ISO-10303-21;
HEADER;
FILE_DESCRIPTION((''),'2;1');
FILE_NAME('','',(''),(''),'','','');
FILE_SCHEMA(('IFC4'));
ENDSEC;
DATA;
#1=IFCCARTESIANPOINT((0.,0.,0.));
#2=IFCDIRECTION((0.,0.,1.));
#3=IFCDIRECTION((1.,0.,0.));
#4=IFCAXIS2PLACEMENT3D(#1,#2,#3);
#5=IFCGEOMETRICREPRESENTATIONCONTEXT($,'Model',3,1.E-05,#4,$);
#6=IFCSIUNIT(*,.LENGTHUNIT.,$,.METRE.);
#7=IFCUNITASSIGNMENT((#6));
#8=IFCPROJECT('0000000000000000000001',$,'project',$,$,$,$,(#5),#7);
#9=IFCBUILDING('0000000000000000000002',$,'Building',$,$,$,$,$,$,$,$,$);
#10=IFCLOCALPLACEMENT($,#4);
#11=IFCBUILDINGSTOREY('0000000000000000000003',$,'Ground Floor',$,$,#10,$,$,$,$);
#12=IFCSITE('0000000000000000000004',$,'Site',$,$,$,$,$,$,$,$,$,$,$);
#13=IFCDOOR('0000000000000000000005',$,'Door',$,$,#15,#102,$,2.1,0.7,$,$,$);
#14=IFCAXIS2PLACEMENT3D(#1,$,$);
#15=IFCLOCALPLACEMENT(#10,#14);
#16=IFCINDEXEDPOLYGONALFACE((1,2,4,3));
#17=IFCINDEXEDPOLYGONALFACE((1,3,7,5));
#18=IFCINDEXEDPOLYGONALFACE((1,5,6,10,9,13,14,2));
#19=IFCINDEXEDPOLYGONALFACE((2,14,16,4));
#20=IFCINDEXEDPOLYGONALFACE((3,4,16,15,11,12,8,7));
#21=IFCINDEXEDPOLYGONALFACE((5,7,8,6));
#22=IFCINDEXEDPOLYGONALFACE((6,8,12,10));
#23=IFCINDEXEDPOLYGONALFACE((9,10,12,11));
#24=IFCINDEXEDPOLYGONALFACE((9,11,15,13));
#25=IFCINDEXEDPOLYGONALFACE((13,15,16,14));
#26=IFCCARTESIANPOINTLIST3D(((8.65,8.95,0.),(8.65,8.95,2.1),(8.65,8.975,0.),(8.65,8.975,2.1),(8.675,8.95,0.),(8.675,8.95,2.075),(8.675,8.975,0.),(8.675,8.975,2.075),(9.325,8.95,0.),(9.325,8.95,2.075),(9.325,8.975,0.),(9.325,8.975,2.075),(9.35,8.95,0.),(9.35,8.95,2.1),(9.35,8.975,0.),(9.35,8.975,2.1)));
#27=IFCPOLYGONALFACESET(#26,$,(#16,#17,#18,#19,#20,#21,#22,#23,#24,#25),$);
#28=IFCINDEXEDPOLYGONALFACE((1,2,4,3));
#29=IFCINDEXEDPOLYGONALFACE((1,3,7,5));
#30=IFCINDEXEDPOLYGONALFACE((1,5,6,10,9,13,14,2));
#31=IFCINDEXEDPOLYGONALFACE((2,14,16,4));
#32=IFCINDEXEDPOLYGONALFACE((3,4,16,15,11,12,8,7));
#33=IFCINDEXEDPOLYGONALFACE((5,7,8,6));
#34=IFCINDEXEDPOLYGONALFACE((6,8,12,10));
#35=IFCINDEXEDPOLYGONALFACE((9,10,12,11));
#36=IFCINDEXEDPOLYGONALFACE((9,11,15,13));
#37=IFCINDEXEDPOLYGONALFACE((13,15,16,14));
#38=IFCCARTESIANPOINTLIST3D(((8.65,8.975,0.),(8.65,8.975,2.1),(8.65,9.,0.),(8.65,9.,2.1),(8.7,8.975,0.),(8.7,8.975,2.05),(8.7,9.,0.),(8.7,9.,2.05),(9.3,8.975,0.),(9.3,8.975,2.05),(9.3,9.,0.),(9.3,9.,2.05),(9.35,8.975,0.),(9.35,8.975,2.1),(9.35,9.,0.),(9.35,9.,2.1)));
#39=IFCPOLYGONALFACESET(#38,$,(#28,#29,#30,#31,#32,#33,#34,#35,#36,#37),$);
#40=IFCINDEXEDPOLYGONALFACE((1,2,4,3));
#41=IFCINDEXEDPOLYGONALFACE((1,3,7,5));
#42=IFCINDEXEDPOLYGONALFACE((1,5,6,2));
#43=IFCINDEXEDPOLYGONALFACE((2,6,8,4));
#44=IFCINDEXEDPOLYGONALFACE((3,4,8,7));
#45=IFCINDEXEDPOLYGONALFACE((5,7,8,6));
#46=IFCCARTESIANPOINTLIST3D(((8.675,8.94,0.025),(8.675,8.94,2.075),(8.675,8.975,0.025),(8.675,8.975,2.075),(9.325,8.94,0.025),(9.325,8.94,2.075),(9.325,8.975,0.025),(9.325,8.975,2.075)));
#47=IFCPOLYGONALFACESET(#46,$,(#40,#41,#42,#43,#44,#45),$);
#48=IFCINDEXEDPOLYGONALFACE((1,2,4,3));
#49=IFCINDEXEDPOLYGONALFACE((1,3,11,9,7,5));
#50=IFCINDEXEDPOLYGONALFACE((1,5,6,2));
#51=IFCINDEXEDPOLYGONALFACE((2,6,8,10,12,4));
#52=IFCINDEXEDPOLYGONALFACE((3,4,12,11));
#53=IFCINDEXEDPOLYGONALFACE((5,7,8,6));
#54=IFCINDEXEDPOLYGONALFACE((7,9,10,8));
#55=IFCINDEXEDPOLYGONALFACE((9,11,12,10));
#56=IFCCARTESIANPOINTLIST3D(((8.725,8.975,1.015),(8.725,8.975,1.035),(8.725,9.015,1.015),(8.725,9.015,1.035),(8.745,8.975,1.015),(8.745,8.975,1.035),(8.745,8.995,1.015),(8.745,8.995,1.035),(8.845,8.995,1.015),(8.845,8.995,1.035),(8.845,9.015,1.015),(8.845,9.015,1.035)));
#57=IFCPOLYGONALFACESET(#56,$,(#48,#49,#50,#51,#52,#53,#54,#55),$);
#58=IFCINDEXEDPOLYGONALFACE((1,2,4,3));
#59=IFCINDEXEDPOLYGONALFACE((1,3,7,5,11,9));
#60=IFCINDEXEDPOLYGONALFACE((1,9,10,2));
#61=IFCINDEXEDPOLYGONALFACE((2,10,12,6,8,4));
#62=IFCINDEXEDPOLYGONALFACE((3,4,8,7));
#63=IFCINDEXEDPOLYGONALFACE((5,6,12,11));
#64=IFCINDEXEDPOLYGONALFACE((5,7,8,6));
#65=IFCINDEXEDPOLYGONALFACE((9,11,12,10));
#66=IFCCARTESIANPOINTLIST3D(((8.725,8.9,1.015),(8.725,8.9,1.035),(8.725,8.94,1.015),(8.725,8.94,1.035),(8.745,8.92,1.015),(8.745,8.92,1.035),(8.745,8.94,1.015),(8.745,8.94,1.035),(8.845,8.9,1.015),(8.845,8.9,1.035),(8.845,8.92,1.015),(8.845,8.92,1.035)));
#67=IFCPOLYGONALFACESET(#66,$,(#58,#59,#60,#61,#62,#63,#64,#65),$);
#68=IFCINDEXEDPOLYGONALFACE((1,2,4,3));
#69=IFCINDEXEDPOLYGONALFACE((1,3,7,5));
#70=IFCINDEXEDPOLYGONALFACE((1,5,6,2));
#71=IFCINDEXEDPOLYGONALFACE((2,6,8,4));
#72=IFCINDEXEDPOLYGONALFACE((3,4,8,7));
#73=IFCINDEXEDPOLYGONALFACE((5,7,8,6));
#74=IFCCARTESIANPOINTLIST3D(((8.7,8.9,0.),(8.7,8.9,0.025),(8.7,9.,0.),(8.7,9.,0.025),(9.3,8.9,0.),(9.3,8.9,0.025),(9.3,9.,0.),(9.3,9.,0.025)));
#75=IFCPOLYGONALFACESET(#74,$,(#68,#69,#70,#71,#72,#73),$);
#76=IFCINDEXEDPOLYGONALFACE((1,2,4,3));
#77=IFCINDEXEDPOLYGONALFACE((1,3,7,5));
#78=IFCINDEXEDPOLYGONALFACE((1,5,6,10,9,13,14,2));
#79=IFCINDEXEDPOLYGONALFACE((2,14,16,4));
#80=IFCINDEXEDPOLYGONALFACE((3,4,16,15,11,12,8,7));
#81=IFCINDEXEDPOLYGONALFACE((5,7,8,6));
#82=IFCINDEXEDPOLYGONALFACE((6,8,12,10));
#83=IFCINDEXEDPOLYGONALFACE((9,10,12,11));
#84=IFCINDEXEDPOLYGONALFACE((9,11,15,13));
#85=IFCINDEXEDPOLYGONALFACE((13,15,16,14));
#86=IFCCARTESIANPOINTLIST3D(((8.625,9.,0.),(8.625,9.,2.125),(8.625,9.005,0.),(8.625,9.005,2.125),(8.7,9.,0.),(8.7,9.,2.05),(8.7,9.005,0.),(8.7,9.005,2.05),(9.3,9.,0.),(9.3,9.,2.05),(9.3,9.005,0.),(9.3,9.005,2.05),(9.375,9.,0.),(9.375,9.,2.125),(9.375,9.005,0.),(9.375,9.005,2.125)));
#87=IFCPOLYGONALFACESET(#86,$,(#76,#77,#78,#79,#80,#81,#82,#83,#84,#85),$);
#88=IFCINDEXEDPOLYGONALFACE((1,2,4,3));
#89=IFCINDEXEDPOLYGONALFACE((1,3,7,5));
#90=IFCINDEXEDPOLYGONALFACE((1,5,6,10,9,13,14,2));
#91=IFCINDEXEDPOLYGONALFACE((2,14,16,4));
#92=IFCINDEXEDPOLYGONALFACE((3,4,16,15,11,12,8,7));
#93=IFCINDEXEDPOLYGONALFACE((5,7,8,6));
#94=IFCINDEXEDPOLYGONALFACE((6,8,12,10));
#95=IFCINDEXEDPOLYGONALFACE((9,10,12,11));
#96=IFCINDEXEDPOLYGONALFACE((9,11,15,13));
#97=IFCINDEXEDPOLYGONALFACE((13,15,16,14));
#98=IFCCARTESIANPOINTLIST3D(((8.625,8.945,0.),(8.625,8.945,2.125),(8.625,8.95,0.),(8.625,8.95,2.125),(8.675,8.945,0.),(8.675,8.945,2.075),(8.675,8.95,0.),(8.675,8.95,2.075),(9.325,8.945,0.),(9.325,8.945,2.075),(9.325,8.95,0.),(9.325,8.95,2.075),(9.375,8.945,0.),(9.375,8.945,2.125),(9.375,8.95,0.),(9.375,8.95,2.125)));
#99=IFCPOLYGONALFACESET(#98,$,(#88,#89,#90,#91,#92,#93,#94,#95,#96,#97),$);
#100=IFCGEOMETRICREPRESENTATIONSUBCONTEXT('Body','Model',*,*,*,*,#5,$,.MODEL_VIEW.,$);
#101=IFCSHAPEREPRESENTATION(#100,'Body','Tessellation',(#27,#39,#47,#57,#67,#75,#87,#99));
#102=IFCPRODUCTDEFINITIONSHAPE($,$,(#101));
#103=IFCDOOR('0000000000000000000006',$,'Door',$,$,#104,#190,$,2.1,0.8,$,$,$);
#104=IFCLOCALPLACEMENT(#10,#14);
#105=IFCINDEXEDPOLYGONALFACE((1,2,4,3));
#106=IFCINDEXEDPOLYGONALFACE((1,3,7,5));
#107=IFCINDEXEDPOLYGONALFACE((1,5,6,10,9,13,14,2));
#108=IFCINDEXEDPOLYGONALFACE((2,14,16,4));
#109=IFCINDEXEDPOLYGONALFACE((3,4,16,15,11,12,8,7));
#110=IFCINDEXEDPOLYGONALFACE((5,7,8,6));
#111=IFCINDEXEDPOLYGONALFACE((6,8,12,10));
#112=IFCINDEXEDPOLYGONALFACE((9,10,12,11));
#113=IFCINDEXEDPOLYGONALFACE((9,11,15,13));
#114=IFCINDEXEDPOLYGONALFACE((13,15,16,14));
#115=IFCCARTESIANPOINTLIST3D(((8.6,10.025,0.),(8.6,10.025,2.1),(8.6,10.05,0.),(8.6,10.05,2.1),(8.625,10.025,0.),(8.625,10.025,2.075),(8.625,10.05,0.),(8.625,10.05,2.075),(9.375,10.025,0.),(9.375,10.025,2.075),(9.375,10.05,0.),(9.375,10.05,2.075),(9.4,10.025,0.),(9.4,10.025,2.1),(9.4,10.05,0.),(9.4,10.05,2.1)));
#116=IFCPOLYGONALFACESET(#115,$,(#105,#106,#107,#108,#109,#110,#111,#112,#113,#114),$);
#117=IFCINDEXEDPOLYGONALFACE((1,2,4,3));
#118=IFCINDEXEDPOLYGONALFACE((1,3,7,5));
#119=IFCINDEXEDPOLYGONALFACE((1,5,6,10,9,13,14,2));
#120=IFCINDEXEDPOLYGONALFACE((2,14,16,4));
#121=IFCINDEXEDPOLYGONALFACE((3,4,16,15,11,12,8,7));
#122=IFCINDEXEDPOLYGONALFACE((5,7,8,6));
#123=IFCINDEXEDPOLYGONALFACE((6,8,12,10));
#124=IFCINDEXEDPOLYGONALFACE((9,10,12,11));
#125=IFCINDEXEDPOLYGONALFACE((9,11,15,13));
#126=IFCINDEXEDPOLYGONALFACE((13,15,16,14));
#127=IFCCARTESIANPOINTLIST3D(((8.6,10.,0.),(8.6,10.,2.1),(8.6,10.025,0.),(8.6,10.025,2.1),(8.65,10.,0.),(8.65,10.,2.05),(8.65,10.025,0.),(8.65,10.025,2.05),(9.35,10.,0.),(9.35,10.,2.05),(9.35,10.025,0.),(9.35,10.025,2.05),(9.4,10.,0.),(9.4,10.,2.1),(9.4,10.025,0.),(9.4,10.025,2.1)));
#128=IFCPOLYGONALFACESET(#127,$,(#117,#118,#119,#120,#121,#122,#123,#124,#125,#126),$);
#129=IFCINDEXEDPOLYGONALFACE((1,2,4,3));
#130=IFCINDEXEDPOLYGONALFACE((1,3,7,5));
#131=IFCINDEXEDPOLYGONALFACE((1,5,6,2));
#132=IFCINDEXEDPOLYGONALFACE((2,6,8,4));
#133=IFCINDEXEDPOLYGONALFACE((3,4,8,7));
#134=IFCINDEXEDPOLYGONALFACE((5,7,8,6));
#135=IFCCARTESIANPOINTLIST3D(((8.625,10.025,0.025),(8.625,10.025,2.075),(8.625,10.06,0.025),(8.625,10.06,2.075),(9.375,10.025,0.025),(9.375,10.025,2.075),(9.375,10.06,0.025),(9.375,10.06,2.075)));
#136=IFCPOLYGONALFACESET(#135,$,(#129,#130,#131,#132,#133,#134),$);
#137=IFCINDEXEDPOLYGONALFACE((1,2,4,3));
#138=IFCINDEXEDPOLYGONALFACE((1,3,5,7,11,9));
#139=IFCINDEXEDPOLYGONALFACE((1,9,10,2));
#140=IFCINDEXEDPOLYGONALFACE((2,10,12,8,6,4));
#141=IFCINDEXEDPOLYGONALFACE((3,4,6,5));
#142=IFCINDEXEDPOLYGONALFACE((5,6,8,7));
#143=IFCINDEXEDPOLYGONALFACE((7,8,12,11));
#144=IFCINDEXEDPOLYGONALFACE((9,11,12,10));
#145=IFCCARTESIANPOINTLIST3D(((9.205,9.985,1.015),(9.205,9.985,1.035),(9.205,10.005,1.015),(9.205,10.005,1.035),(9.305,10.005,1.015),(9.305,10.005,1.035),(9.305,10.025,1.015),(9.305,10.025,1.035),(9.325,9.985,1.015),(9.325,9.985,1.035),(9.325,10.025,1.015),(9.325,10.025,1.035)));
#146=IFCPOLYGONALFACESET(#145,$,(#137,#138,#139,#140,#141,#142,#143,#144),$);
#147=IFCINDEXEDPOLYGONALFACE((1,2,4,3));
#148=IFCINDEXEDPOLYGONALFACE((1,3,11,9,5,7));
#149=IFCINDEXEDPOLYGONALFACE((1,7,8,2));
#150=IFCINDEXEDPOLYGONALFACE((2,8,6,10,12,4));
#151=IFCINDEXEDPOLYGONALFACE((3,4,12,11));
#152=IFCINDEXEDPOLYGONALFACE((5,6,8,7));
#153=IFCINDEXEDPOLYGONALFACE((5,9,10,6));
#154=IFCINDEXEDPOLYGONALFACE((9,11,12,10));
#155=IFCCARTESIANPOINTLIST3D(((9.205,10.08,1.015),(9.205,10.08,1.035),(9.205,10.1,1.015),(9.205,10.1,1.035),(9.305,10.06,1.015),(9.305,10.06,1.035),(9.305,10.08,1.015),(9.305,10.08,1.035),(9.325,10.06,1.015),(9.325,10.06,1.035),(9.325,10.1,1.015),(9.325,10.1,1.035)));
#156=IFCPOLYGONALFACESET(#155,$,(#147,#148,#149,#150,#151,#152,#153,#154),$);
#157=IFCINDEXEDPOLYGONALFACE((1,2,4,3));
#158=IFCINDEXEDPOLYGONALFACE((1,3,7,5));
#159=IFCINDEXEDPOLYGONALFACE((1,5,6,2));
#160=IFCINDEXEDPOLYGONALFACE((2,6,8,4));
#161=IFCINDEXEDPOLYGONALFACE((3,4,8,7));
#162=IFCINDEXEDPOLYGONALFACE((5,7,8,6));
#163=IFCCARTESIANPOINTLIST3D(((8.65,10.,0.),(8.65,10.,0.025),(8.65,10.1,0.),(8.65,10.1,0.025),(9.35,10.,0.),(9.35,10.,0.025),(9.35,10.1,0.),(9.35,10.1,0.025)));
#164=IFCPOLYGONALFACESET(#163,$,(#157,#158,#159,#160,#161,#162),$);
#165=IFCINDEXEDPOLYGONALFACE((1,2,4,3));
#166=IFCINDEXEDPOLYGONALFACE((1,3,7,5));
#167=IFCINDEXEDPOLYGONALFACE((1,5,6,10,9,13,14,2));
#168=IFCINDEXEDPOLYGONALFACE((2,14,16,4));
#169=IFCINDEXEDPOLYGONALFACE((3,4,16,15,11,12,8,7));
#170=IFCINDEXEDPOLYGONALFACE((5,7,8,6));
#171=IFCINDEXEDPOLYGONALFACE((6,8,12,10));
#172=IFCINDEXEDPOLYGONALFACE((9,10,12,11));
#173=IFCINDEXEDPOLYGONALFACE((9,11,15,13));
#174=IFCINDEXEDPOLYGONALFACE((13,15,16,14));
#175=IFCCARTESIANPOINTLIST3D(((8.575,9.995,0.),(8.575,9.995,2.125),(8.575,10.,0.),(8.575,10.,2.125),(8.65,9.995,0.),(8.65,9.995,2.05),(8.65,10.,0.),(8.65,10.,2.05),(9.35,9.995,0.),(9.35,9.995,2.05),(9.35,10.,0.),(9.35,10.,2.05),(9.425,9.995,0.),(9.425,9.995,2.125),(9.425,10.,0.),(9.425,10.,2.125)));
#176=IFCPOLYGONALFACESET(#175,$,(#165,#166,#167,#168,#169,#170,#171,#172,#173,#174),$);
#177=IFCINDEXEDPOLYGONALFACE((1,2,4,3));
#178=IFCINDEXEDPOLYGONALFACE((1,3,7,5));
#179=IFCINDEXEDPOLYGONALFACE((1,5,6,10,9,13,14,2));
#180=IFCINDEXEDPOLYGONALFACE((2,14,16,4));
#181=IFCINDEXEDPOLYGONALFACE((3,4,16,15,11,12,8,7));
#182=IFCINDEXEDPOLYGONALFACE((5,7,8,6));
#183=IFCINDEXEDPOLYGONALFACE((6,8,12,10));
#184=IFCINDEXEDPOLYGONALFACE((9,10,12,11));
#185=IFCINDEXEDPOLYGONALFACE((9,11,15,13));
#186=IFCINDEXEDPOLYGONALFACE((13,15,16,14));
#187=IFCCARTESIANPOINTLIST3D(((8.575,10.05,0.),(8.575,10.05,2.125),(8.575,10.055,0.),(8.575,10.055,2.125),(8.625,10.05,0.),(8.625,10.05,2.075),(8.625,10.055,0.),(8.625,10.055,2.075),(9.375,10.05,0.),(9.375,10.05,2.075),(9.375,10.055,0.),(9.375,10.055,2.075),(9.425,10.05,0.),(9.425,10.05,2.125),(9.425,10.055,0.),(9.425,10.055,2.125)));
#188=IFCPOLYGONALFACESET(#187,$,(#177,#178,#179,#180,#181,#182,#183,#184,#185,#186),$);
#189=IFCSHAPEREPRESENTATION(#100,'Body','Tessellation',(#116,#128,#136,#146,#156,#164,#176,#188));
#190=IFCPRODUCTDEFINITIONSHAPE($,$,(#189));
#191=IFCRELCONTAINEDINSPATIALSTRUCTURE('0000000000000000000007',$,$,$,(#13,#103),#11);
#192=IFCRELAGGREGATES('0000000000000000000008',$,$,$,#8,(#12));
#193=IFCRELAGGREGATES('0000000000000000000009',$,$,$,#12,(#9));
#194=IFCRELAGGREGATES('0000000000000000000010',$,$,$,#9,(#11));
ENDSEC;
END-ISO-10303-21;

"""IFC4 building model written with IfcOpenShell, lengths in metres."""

from ifc_helpers import new_model, si_unit, frame, origin_with_axes, place, context, subcontext, project, spatial, line, indexed_curve, outline, extrude, element, save


model = new_model("IFC4")

# Units and contexts
model_context = context("Model", 3, precision=1e-05, world=origin_with_axes())
body_context = subcontext(model_context, "Body", "Model", "MODEL_VIEW")
ifc_project = project(units=[si_unit("LENGTHUNIT", "METRE")], contexts=[model_context])

# Site, building, storey
site = spatial("IfcSite", under=ifc_project, Name="Site")
building = spatial("IfcBuilding", under=site, Name="Building")
storey_placement = place(None, origin_with_axes())
storey = spatial("IfcBuildingStorey", under=building, at=storey_placement, Name="Ground Floor")

# Doors
door_1_placement = place(storey_placement, frame((9.35, 9.0, 0.0), z_axis=(0.0, 0.0, 1.0), x_axis=(-1.0, 0.0, 0.0)))
element("IfcDoor", 1, at=door_1_placement, inside=storey, Name="Door", OverallHeight=2.1, OverallWidth=0.7, context=body_context, shape_type="SweptSolid", body=[
    extrude(outline(indexed_curve([(0.0, 0.0), (0.0, 2.1), (0.7, 2.1), (0.7, 0.0), (0.675, 0.0), (0.675, 2.075), (0.025, 2.075), (0.025, 0.0)], segments=[line(1, 2, 3, 4, 5, 6, 7, 8, 1)])), frame((0.0, 0.025, 0.0), z_axis=(0.0, -1.0, 0.0), x_axis=(1.0, 0.0, 0.0)), (0.0, 0.0, -1.0), 0.025),
    extrude(outline(indexed_curve([(0.0, 0.0), (0.0, 2.1), (0.7, 2.1), (0.7, 0.0), (0.65, 0.0), (0.65, 2.05), (0.05, 2.05), (0.05, 0.0)], segments=[line(1, 2, 3, 4, 5, 6, 7, 8, 1)])), frame((0.0, 0.0, 0.0), z_axis=(0.0, -1.0, 0.0), x_axis=(1.0, 0.0, 0.0)), (0.0, 0.0, -1.0), 0.025),
    extrude(outline(indexed_curve([(0.0, 0.0), (0.65, 0.0), (0.65, 0.035), (0.0, 0.035)], segments=[line(1, 2, 3, 4, 1)])), frame((0.025, 0.025, 0.025), z_axis=(0.0, 0.0, 1.0), x_axis=(1.0, 0.0, 0.0)), (0.0, 0.0, 1.0), 2.05),
    extrude(outline(indexed_curve([(0.0, 0.0), (0.0, -0.04), (-0.12, -0.04), (-0.12, -0.02), (-0.02, -0.02), (-0.02, 0.0)], segments=[line(1, 2, 3, 4, 5, 6, 1)])), frame((0.625, 0.025, 1.015), z_axis=(0.0, 0.0, 1.0), x_axis=(1.0, 0.0, 0.0)), (0.0, 0.0, 1.0), 0.02),
    extrude(outline(indexed_curve([(0.0, 0.0), (0.0, 0.04), (-0.12, 0.04), (-0.12, 0.02), (-0.02, 0.02), (-0.02, 0.0)], segments=[line(1, 2, 3, 4, 5, 6, 1)])), frame((0.625, 0.06, 1.015), z_axis=(0.0, 0.0, 1.0), x_axis=(1.0, 0.0, 0.0)), (0.0, 0.0, 1.0), 0.02),
    extrude(outline(indexed_curve([(0.0, 0.0), (0.6, 0.0), (0.6, 0.1), (0.0, 0.1)], segments=[line(1, 2, 3, 4, 1)])), frame((0.05, 0.0, 0.0), z_axis=(0.0, 0.0, 1.0), x_axis=(1.0, 0.0, 0.0)), (0.0, 0.0, 1.0), 0.025),
    extrude(outline(indexed_curve([(0.0, 0.0), (0.0, 2.125), (0.75, 2.125), (0.75, 0.0), (0.675, 0.0), (0.675, 2.05), (0.075, 2.05), (0.075, 0.0)], segments=[line(1, 2, 3, 4, 5, 6, 7, 8, 1)])), frame((-0.025, -0.005, 0.0), z_axis=(0.0, -1.0, 0.0), x_axis=(1.0, 0.0, 0.0)), (0.0, 0.0, -1.0), 0.005),
    extrude(outline(indexed_curve([(0.0, 0.0), (0.0, 2.125), (0.75, 2.125), (0.75, 0.0), (0.7, 0.0), (0.7, 2.075), (0.05, 2.075), (0.05, 0.0)], segments=[line(1, 2, 3, 4, 5, 6, 7, 8, 1)])), frame((-0.025, 0.05, 0.0), z_axis=(0.0, -1.0, 0.0), x_axis=(1.0, 0.0, 0.0)), (0.0, 0.0, -1.0), 0.005),
])
door_2_placement = place(storey_placement, frame((8.6, 10.0, 0.0), z_axis=(0.0, 0.0, 1.0), x_axis=(1.0, 0.0, 0.0)))
element("IfcDoor", 2, at=door_2_placement, inside=storey, Name="Door", OverallHeight=2.1, OverallWidth=0.8, context=body_context, shape_type="SweptSolid", body=[
    extrude(outline(indexed_curve([(0.0, 0.0), (0.0, 2.1), (0.8, 2.1), (0.8, 0.0), (0.775, 0.0), (0.775, 2.075), (0.025, 2.075), (0.025, 0.0)], segments=[line(1, 2, 3, 4, 5, 6, 7, 8, 1)])), frame((0.0, 0.025, 0.0), z_axis=(0.0, -1.0, 0.0), x_axis=(1.0, 0.0, 0.0)), (0.0, 0.0, -1.0), 0.025),
    extrude(outline(indexed_curve([(0.0, 0.0), (0.0, 2.1), (0.8, 2.1), (0.8, 0.0), (0.75, 0.0), (0.75, 2.05), (0.05, 2.05), (0.05, 0.0)], segments=[line(1, 2, 3, 4, 5, 6, 7, 8, 1)])), frame((0.0, 0.0, 0.0), z_axis=(0.0, -1.0, 0.0), x_axis=(1.0, 0.0, 0.0)), (0.0, 0.0, -1.0), 0.025),
    extrude(outline(indexed_curve([(0.0, 0.0), (0.75, 0.0), (0.75, 0.035), (0.0, 0.035)], segments=[line(1, 2, 3, 4, 1)])), frame((0.025, 0.025, 0.025), z_axis=(0.0, 0.0, 1.0), x_axis=(1.0, 0.0, 0.0)), (0.0, 0.0, 1.0), 2.05),
    extrude(outline(indexed_curve([(0.0, 0.0), (0.0, -0.04), (-0.12, -0.04), (-0.12, -0.02), (-0.02, -0.02), (-0.02, 0.0)], segments=[line(1, 2, 3, 4, 5, 6, 1)])), frame((0.725, 0.025, 1.015), z_axis=(0.0, 0.0, 1.0), x_axis=(1.0, 0.0, 0.0)), (0.0, 0.0, 1.0), 0.02),
    extrude(outline(indexed_curve([(0.0, 0.0), (0.0, 0.04), (-0.12, 0.04), (-0.12, 0.02), (-0.02, 0.02), (-0.02, 0.0)], segments=[line(1, 2, 3, 4, 5, 6, 1)])), frame((0.725, 0.06, 1.015), z_axis=(0.0, 0.0, 1.0), x_axis=(1.0, 0.0, 0.0)), (0.0, 0.0, 1.0), 0.02),
    extrude(outline(indexed_curve([(0.0, 0.0), (0.7, 0.0), (0.7, 0.1), (0.0, 0.1)], segments=[line(1, 2, 3, 4, 1)])), frame((0.05, 0.0, 0.0), z_axis=(0.0, 0.0, 1.0), x_axis=(1.0, 0.0, 0.0)), (0.0, 0.0, 1.0), 0.025),
    extrude(outline(indexed_curve([(0.0, 0.0), (0.0, 2.125), (0.85, 2.125), (0.85, 0.0), (0.775, 0.0), (0.775, 2.05), (0.075, 2.05), (0.075, 0.0)], segments=[line(1, 2, 3, 4, 5, 6, 7, 8, 1)])), frame((-0.025, -0.005, 0.0), z_axis=(0.0, -1.0, 0.0), x_axis=(1.0, 0.0, 0.0)), (0.0, 0.0, -1.0), 0.005),
    extrude(outline(indexed_curve([(0.0, 0.0), (0.0, 2.125), (0.85, 2.125), (0.85, 0.0), (0.8, 0.0), (0.8, 2.075), (0.05, 2.075), (0.05, 0.0)], segments=[line(1, 2, 3, 4, 5, 6, 7, 8, 1)])), frame((-0.025, 0.05, 0.0), z_axis=(0.0, -1.0, 0.0), x_axis=(1.0, 0.0, 0.0)), (0.0, 0.0, -1.0), 0.005),
])

save(model, "model.ifc")
